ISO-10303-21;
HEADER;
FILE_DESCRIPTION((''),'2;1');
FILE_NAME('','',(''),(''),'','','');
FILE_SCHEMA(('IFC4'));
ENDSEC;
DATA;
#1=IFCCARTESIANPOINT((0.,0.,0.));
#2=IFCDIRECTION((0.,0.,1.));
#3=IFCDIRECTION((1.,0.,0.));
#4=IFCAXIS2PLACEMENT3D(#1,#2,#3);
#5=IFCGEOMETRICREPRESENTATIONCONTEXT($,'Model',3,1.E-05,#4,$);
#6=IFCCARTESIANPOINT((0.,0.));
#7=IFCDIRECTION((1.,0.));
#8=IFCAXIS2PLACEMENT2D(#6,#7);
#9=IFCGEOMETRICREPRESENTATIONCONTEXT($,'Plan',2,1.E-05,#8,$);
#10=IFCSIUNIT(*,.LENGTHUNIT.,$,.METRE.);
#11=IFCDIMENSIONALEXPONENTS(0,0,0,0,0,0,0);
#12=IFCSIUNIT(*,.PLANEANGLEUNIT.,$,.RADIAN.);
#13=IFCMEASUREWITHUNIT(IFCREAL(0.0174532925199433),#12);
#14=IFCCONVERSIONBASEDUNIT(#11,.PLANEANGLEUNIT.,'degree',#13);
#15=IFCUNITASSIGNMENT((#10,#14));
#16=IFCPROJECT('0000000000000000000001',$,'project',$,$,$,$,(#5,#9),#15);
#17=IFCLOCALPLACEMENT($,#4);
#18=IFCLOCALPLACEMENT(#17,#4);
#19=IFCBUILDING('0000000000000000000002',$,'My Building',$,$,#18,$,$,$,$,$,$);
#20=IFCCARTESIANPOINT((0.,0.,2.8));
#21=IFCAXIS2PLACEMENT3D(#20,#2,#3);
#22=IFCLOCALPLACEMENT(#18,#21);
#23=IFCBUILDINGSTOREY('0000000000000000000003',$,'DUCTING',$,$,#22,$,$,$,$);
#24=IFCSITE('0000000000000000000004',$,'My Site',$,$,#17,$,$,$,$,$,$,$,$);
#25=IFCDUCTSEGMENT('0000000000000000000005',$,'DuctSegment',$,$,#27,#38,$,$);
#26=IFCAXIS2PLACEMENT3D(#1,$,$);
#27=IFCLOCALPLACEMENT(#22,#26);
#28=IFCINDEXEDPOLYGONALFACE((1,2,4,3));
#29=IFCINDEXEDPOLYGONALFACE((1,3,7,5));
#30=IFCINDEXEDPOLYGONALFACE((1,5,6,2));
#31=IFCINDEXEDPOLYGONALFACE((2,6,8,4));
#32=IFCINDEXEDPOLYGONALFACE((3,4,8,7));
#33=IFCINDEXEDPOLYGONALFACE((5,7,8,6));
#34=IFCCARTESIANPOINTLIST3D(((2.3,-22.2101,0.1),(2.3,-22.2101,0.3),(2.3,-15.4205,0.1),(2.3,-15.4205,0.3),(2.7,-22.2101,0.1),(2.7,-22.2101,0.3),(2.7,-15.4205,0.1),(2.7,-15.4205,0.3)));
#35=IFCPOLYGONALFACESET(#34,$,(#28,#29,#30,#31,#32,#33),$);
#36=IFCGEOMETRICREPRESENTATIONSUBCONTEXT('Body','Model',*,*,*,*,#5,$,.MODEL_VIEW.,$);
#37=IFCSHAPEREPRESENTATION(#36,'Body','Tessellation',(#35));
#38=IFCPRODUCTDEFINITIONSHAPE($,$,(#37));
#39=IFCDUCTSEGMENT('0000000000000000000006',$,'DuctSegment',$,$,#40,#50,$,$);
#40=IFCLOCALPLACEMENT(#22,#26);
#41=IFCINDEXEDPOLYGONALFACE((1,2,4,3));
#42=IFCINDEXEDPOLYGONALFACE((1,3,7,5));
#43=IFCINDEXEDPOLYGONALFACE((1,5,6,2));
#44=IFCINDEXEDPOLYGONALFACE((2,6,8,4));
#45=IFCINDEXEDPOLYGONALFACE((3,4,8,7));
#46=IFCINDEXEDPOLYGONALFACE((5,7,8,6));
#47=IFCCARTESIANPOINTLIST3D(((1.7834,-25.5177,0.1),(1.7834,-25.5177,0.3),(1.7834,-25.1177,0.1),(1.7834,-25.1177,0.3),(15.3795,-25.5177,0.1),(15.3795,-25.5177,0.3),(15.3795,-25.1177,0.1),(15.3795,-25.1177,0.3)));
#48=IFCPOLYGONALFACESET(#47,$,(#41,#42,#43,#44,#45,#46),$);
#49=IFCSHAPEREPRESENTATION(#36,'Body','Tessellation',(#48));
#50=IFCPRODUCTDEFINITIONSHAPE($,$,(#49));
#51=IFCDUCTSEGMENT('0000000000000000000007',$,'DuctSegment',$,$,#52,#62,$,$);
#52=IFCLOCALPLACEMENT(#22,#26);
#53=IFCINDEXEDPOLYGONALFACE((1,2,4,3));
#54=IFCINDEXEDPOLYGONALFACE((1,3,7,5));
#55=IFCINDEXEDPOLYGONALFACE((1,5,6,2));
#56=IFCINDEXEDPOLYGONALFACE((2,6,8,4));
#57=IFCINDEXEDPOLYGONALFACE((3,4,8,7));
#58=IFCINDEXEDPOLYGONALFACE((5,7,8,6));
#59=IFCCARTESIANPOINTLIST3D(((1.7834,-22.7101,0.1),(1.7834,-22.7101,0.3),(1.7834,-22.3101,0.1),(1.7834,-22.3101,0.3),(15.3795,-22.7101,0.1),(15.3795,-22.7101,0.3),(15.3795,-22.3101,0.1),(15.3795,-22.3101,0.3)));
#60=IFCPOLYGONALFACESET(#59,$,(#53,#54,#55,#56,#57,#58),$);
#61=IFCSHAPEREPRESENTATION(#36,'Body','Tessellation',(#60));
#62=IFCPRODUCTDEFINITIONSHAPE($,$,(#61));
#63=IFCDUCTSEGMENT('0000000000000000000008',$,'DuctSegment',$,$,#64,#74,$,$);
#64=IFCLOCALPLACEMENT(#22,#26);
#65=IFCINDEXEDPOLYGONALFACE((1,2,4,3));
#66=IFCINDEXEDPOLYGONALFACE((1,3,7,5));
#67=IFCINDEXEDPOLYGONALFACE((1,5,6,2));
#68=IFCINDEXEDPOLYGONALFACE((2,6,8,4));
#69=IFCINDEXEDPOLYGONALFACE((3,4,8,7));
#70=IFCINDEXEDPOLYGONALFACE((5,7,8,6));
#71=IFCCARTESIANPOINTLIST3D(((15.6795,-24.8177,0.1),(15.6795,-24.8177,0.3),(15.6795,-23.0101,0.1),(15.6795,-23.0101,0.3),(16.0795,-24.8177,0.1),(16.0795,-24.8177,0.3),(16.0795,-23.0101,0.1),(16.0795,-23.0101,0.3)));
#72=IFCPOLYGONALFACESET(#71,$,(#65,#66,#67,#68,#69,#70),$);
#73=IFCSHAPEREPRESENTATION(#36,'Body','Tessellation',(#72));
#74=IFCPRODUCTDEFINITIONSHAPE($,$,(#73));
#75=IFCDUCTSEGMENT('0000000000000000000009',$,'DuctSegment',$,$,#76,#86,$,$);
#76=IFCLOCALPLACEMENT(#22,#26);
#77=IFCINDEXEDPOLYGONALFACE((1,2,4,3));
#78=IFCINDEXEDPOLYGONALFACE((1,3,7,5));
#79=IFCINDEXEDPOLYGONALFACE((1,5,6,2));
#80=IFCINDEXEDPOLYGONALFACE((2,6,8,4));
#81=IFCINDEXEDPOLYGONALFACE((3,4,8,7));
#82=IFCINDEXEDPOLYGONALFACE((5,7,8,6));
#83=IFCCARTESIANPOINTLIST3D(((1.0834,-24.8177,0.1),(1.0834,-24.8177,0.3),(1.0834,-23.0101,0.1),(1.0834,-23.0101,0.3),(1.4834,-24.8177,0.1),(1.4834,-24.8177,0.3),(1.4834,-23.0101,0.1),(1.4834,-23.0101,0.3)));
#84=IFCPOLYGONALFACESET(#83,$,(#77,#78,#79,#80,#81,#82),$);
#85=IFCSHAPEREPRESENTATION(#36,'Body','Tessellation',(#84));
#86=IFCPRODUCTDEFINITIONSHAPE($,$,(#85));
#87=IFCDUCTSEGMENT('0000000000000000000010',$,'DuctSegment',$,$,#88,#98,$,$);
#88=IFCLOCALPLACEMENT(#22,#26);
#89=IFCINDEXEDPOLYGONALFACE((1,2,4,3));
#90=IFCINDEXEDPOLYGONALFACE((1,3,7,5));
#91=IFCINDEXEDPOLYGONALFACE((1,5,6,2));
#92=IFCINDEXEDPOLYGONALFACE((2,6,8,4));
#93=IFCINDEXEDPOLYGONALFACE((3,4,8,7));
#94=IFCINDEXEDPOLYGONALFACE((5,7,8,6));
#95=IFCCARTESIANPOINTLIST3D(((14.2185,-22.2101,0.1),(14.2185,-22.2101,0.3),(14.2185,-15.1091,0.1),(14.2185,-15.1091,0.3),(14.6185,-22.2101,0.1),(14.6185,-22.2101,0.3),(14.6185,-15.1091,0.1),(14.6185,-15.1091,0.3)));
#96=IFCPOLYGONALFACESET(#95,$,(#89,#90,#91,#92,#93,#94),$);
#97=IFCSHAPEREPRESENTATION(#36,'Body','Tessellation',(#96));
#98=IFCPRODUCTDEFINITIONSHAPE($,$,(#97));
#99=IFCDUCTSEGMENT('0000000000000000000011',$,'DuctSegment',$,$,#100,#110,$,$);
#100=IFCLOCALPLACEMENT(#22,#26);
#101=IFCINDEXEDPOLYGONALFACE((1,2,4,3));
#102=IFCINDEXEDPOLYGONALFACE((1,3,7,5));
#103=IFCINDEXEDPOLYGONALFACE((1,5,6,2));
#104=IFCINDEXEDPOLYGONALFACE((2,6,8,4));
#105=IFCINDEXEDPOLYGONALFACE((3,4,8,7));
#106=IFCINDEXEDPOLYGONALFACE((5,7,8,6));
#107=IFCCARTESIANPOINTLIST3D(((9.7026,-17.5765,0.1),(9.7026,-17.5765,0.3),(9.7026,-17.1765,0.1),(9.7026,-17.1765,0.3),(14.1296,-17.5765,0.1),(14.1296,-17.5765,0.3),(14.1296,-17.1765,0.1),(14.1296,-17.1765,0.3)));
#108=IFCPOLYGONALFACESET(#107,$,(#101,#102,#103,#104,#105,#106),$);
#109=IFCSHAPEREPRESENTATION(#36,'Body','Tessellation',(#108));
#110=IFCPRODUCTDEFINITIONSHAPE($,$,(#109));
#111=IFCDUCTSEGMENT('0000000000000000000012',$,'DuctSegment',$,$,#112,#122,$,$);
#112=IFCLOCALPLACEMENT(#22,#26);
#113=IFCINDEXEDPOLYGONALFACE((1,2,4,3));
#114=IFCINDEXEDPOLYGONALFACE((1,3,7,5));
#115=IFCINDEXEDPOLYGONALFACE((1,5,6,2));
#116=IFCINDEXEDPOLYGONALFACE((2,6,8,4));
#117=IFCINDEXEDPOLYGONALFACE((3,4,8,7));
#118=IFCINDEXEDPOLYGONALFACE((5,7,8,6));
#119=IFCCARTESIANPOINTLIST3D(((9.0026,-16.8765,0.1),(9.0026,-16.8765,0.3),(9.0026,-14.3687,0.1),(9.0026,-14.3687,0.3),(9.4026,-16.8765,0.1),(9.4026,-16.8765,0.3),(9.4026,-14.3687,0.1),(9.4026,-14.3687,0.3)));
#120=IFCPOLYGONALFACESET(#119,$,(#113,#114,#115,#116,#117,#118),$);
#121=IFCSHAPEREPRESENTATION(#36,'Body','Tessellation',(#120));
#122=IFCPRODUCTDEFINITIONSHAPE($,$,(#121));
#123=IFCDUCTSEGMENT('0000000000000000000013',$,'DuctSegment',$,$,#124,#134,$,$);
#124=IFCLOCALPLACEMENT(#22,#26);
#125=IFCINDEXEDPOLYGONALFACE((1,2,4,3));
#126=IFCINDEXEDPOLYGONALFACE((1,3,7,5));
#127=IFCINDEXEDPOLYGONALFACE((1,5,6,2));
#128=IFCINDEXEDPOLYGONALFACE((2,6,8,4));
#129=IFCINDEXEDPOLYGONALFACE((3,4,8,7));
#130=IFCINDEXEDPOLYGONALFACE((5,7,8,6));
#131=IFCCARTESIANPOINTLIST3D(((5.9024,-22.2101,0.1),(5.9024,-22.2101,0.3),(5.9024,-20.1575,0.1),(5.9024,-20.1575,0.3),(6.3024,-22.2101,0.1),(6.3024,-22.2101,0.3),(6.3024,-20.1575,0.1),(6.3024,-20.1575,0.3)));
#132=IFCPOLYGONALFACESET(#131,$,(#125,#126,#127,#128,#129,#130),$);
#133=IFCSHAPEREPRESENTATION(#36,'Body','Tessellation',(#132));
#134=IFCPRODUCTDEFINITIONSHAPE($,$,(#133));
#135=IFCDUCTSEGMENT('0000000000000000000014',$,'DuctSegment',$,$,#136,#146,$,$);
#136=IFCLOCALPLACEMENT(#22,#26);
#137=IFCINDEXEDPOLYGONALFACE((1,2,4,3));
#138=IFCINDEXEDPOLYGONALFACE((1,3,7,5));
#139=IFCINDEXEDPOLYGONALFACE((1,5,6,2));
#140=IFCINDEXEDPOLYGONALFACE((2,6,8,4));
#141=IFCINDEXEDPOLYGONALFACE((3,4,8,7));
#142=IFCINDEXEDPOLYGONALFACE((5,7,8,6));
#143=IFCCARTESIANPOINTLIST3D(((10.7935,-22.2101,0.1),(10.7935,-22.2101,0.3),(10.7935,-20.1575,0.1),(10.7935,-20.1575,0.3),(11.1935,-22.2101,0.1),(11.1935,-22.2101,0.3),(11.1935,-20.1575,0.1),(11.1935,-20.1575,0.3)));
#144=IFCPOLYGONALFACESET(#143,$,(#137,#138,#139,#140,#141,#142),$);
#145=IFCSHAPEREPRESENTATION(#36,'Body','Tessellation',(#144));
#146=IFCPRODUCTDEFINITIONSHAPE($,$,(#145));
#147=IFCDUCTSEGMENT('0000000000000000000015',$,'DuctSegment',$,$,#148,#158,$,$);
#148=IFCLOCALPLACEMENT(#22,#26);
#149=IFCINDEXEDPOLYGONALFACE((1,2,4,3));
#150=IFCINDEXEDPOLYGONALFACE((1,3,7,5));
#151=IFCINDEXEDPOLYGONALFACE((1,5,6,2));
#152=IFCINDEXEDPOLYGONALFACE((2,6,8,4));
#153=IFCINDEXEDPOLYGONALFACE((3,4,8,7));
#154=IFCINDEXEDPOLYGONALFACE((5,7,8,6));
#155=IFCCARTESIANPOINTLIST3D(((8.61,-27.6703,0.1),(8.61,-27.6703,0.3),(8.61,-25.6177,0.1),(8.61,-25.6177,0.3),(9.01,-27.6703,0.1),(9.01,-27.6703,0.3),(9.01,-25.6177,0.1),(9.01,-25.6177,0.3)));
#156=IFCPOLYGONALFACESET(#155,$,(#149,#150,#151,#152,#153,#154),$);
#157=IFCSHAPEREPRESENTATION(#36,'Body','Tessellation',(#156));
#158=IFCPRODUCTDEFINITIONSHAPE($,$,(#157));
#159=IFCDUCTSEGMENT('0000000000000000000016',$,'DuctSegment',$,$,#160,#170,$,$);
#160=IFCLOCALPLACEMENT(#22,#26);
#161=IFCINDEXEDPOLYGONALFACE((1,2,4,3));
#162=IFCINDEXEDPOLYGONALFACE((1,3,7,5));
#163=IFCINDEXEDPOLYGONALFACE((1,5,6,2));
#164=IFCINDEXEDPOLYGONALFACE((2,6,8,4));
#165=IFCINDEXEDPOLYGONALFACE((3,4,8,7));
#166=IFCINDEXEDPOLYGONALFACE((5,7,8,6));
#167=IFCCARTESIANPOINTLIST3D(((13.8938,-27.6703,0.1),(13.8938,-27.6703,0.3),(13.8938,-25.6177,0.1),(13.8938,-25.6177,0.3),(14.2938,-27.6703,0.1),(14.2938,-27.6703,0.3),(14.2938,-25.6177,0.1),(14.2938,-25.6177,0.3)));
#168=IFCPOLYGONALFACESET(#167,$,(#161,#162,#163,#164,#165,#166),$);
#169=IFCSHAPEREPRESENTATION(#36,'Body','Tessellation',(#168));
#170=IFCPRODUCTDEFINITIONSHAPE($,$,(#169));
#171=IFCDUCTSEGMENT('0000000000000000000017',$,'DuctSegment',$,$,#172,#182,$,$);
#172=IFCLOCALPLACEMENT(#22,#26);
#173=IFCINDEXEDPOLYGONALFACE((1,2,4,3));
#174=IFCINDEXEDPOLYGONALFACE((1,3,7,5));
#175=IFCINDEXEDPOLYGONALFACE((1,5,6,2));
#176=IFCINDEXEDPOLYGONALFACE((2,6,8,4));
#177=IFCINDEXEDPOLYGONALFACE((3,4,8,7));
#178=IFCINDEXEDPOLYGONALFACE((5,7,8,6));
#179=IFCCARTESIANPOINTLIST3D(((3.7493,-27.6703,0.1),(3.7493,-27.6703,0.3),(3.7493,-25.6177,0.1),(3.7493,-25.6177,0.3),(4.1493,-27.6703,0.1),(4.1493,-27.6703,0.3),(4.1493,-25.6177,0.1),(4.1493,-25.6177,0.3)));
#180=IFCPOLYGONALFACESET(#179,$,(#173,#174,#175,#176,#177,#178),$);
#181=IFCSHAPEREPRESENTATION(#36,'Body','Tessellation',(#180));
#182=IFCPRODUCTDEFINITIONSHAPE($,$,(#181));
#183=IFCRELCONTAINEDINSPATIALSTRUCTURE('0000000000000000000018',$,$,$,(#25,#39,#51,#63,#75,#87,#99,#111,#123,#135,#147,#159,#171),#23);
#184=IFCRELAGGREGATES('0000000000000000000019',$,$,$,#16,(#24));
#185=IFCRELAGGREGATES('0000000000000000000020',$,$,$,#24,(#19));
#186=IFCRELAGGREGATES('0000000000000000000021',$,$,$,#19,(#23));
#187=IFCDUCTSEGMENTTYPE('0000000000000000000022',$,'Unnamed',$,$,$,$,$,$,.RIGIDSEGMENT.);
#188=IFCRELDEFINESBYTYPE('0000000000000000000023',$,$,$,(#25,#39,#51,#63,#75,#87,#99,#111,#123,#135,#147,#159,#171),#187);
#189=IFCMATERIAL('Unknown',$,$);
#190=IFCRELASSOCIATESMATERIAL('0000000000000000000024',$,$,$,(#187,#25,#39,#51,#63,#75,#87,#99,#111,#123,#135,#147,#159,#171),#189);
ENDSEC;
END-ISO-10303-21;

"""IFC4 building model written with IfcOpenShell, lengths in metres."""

from ifc_helpers import new_model, entity, si_unit, converted_unit, frame, origin_with_axes, origin_2d_with_axis, place, context, subcontext, project, spatial, rectangle, extrude, material, material_profile, profile_set, profile_usage, type_object, element, save


model = new_model("IFC4")

# Units and contexts
model_context = context("Model", 3, precision=1e-05, world=origin_with_axes())
plan_context = context("Plan", 2, precision=1e-05, world=origin_2d_with_axis())
body_context = subcontext(model_context, "Body", "Model", "MODEL_VIEW")
ifc_project = project(units=[si_unit("LENGTHUNIT", "METRE"), converted_unit("PLANEANGLEUNIT", "degree", entity("IfcReal", 0.0174532925199433), si_unit("PLANEANGLEUNIT", "RADIAN"), dimensions=[0, 0, 0, 0, 0, 0, 0])], contexts=[model_context, plan_context])

# Site, building, storey
site_placement = place(None, origin_with_axes())
site = spatial("IfcSite", under=ifc_project, at=site_placement, Name="My Site")
building_placement = place(site_placement, origin_with_axes())
building = spatial("IfcBuilding", under=site, at=building_placement, Name="My Building")
storey_placement = place(building_placement, frame((0.0, 0.0, 2.8), z_axis=(0.0, 0.0, 1.0), x_axis=(1.0, 0.0, 0.0)))
storey = spatial("IfcBuildingStorey", under=building, at=storey_placement, Name="DUCTING")

# Duct segments
ifc_material = material(Name="Unknown")
ifc_material_profile_1 = material_profile(ifc_material, rectangle(XDim=0.4, YDim=0.2))
ifc_profile_set_1 = profile_set([ifc_material_profile_1])
ifc_profile_usage_1 = profile_usage(ifc_profile_set_1, cardinal=5)
duct_segment_type = type_object("IfcDuctSegmentType", Name="Unnamed", PredefinedType="RIGIDSEGMENT", material=ifc_profile_set_1)
duct_segment_1_placement = place(storey_placement, frame((2.5, -15.4205, 0.2), z_axis=(0.0, -1.0, 0.0), x_axis=(1.0, 0.0, 0.0)))
element("IfcDuctSegment", 1, at=duct_segment_1_placement, inside=storey, type_object=duct_segment_type, material=ifc_profile_usage_1, Name="DuctSegment", context=body_context, shape_type="SweptSolid", body=[
    extrude(rectangle(XDim=0.4, YDim=0.2), origin_with_axes(), (0.0, 0.0, 1.0), 6.7896),
])
ifc_profile_usage_2 = profile_usage(ifc_profile_set_1, cardinal=5)
duct_segment_2_placement = place(storey_placement, frame((1.7834, -25.3177, 0.2), z_axis=(1.0, 0.0, 0.0), x_axis=(0.0, 1.0, 0.0)))
element("IfcDuctSegment", 2, at=duct_segment_2_placement, inside=storey, type_object=duct_segment_type, material=ifc_profile_usage_2, Name="DuctSegment", context=body_context, shape_type="SweptSolid", body=[
    extrude(rectangle(XDim=0.4, YDim=0.2), origin_with_axes(), (0.0, 0.0, 1.0), 13.5961),
])
ifc_profile_usage_3 = profile_usage(ifc_profile_set_1, cardinal=5)
duct_segment_3_placement = place(storey_placement, frame((1.7834, -22.5101, 0.2), z_axis=(1.0, 0.0, 0.0), x_axis=(0.0, 1.0, 0.0)))
element("IfcDuctSegment", 3, at=duct_segment_3_placement, inside=storey, type_object=duct_segment_type, material=ifc_profile_usage_3, Name="DuctSegment", context=body_context, shape_type="SweptSolid", body=[
    extrude(rectangle(XDim=0.4, YDim=0.2), origin_with_axes(), (0.0, 0.0, 1.0), 13.5961),
])
ifc_profile_usage_4 = profile_usage(ifc_profile_set_1, cardinal=5)
duct_segment_4_placement = place(storey_placement, frame((15.8795, -23.0101, 0.2), z_axis=(0.0, -1.0, 0.0), x_axis=(1.0, 0.0, 0.0)))
element("IfcDuctSegment", 4, at=duct_segment_4_placement, inside=storey, type_object=duct_segment_type, material=ifc_profile_usage_4, Name="DuctSegment", context=body_context, shape_type="SweptSolid", body=[
    extrude(rectangle(XDim=0.4, YDim=0.2), origin_with_axes(), (0.0, 0.0, 1.0), 1.8076),
])
ifc_profile_usage_5 = profile_usage(ifc_profile_set_1, cardinal=5)
duct_segment_5_placement = place(storey_placement, frame((1.2834, -23.0101, 0.2), z_axis=(0.0, -1.0, 0.0), x_axis=(1.0, 0.0, 0.0)))
element("IfcDuctSegment", 5, at=duct_segment_5_placement, inside=storey, type_object=duct_segment_type, material=ifc_profile_usage_5, Name="DuctSegment", context=body_context, shape_type="SweptSolid", body=[
    extrude(rectangle(XDim=0.4, YDim=0.2), origin_with_axes(), (0.0, 0.0, 1.0), 1.8076),
])
ifc_profile_usage_6 = profile_usage(ifc_profile_set_1, cardinal=5)
duct_segment_6_placement = place(storey_placement, frame((14.4185, -22.2101, 0.2), z_axis=(0.0, 1.0, 0.0), x_axis=(-1.0, 0.0, 0.0)))
element("IfcDuctSegment", 6, at=duct_segment_6_placement, inside=storey, type_object=duct_segment_type, material=ifc_profile_usage_6, Name="DuctSegment", context=body_context, shape_type="SweptSolid", body=[
    extrude(rectangle(XDim=0.4, YDim=0.2), origin_with_axes(), (0.0, 0.0, 1.0), 7.101),
])
ifc_profile_usage_7 = profile_usage(ifc_profile_set_1, cardinal=5)
duct_segment_7_placement = place(storey_placement, frame((14.1296, -17.3765, 0.2), z_axis=(-1.0, 0.0, 0.0), x_axis=(0.0, -1.0, 0.0)))
element("IfcDuctSegment", 7, at=duct_segment_7_placement, inside=storey, type_object=duct_segment_type, material=ifc_profile_usage_7, Name="DuctSegment", context=body_context, shape_type="SweptSolid", body=[
    extrude(rectangle(XDim=0.4, YDim=0.2), origin_with_axes(), (0.0, 0.0, 1.0), 4.427),
])
ifc_profile_usage_8 = profile_usage(ifc_profile_set_1, cardinal=5)
duct_segment_8_placement = place(storey_placement, frame((9.2026, -16.8765, 0.2), z_axis=(0.0, 1.0, 0.0), x_axis=(-1.0, 0.0, 0.0)))
element("IfcDuctSegment", 8, at=duct_segment_8_placement, inside=storey, type_object=duct_segment_type, material=ifc_profile_usage_8, Name="DuctSegment", context=body_context, shape_type="SweptSolid", body=[
    extrude(rectangle(XDim=0.4, YDim=0.2), origin_with_axes(), (0.0, 0.0, 1.0), 2.5078),
])
ifc_profile_usage_9 = profile_usage(ifc_profile_set_1, cardinal=5)
duct_segment_9_placement = place(storey_placement, frame((6.1024, -22.2101, 0.2), z_axis=(0.0, 1.0, 0.0), x_axis=(-1.0, 0.0, 0.0)))
element("IfcDuctSegment", 9, at=duct_segment_9_placement, inside=storey, type_object=duct_segment_type, material=ifc_profile_usage_9, Name="DuctSegment", context=body_context, shape_type="SweptSolid", body=[
    extrude(rectangle(XDim=0.4, YDim=0.2), origin_with_axes(), (0.0, 0.0, 1.0), 2.0526),
])
ifc_profile_usage_10 = profile_usage(ifc_profile_set_1, cardinal=5)
duct_segment_10_placement = place(storey_placement, frame((10.9935, -22.2101, 0.2), z_axis=(0.0, 1.0, 0.0), x_axis=(-1.0, 0.0, 0.0)))
element("IfcDuctSegment", 10, at=duct_segment_10_placement, inside=storey, type_object=duct_segment_type, material=ifc_profile_usage_10, Name="DuctSegment", context=body_context, shape_type="SweptSolid", body=[
    extrude(rectangle(XDim=0.4, YDim=0.2), origin_with_axes(), (0.0, 0.0, 1.0), 2.0526),
])
ifc_profile_usage_11 = profile_usage(ifc_profile_set_1, cardinal=5)
duct_segment_11_placement = place(storey_placement, frame((8.81, -25.6177, 0.2), z_axis=(0.0, -1.0, 0.0), x_axis=(1.0, 0.0, 0.0)))
element("IfcDuctSegment", 11, at=duct_segment_11_placement, inside=storey, type_object=duct_segment_type, material=ifc_profile_usage_11, Name="DuctSegment", context=body_context, shape_type="SweptSolid", body=[
    extrude(rectangle(XDim=0.4, YDim=0.2), origin_with_axes(), (0.0, 0.0, 1.0), 2.0526),
])
ifc_profile_usage_12 = profile_usage(ifc_profile_set_1, cardinal=5)
duct_segment_12_placement = place(storey_placement, frame((14.0938, -25.6177, 0.2), z_axis=(0.0, -1.0, 0.0), x_axis=(1.0, 0.0, 0.0)))
element("IfcDuctSegment", 12, at=duct_segment_12_placement, inside=storey, type_object=duct_segment_type, material=ifc_profile_usage_12, Name="DuctSegment", context=body_context, shape_type="SweptSolid", body=[
    extrude(rectangle(XDim=0.4, YDim=0.2), origin_with_axes(), (0.0, 0.0, 1.0), 2.0526),
])
ifc_profile_usage_13 = profile_usage(ifc_profile_set_1, cardinal=5)
duct_segment_13_placement = place(storey_placement, frame((3.9493, -25.6177, 0.2), z_axis=(0.0, -1.0, 0.0), x_axis=(1.0, 0.0, 0.0)))
element("IfcDuctSegment", 13, at=duct_segment_13_placement, inside=storey, type_object=duct_segment_type, material=ifc_profile_usage_13, Name="DuctSegment", context=body_context, shape_type="SweptSolid", body=[
    extrude(rectangle(XDim=0.4, YDim=0.2), origin_with_axes(), (0.0, 0.0, 1.0), 2.0526),
])

save(model, "model.ifc")
